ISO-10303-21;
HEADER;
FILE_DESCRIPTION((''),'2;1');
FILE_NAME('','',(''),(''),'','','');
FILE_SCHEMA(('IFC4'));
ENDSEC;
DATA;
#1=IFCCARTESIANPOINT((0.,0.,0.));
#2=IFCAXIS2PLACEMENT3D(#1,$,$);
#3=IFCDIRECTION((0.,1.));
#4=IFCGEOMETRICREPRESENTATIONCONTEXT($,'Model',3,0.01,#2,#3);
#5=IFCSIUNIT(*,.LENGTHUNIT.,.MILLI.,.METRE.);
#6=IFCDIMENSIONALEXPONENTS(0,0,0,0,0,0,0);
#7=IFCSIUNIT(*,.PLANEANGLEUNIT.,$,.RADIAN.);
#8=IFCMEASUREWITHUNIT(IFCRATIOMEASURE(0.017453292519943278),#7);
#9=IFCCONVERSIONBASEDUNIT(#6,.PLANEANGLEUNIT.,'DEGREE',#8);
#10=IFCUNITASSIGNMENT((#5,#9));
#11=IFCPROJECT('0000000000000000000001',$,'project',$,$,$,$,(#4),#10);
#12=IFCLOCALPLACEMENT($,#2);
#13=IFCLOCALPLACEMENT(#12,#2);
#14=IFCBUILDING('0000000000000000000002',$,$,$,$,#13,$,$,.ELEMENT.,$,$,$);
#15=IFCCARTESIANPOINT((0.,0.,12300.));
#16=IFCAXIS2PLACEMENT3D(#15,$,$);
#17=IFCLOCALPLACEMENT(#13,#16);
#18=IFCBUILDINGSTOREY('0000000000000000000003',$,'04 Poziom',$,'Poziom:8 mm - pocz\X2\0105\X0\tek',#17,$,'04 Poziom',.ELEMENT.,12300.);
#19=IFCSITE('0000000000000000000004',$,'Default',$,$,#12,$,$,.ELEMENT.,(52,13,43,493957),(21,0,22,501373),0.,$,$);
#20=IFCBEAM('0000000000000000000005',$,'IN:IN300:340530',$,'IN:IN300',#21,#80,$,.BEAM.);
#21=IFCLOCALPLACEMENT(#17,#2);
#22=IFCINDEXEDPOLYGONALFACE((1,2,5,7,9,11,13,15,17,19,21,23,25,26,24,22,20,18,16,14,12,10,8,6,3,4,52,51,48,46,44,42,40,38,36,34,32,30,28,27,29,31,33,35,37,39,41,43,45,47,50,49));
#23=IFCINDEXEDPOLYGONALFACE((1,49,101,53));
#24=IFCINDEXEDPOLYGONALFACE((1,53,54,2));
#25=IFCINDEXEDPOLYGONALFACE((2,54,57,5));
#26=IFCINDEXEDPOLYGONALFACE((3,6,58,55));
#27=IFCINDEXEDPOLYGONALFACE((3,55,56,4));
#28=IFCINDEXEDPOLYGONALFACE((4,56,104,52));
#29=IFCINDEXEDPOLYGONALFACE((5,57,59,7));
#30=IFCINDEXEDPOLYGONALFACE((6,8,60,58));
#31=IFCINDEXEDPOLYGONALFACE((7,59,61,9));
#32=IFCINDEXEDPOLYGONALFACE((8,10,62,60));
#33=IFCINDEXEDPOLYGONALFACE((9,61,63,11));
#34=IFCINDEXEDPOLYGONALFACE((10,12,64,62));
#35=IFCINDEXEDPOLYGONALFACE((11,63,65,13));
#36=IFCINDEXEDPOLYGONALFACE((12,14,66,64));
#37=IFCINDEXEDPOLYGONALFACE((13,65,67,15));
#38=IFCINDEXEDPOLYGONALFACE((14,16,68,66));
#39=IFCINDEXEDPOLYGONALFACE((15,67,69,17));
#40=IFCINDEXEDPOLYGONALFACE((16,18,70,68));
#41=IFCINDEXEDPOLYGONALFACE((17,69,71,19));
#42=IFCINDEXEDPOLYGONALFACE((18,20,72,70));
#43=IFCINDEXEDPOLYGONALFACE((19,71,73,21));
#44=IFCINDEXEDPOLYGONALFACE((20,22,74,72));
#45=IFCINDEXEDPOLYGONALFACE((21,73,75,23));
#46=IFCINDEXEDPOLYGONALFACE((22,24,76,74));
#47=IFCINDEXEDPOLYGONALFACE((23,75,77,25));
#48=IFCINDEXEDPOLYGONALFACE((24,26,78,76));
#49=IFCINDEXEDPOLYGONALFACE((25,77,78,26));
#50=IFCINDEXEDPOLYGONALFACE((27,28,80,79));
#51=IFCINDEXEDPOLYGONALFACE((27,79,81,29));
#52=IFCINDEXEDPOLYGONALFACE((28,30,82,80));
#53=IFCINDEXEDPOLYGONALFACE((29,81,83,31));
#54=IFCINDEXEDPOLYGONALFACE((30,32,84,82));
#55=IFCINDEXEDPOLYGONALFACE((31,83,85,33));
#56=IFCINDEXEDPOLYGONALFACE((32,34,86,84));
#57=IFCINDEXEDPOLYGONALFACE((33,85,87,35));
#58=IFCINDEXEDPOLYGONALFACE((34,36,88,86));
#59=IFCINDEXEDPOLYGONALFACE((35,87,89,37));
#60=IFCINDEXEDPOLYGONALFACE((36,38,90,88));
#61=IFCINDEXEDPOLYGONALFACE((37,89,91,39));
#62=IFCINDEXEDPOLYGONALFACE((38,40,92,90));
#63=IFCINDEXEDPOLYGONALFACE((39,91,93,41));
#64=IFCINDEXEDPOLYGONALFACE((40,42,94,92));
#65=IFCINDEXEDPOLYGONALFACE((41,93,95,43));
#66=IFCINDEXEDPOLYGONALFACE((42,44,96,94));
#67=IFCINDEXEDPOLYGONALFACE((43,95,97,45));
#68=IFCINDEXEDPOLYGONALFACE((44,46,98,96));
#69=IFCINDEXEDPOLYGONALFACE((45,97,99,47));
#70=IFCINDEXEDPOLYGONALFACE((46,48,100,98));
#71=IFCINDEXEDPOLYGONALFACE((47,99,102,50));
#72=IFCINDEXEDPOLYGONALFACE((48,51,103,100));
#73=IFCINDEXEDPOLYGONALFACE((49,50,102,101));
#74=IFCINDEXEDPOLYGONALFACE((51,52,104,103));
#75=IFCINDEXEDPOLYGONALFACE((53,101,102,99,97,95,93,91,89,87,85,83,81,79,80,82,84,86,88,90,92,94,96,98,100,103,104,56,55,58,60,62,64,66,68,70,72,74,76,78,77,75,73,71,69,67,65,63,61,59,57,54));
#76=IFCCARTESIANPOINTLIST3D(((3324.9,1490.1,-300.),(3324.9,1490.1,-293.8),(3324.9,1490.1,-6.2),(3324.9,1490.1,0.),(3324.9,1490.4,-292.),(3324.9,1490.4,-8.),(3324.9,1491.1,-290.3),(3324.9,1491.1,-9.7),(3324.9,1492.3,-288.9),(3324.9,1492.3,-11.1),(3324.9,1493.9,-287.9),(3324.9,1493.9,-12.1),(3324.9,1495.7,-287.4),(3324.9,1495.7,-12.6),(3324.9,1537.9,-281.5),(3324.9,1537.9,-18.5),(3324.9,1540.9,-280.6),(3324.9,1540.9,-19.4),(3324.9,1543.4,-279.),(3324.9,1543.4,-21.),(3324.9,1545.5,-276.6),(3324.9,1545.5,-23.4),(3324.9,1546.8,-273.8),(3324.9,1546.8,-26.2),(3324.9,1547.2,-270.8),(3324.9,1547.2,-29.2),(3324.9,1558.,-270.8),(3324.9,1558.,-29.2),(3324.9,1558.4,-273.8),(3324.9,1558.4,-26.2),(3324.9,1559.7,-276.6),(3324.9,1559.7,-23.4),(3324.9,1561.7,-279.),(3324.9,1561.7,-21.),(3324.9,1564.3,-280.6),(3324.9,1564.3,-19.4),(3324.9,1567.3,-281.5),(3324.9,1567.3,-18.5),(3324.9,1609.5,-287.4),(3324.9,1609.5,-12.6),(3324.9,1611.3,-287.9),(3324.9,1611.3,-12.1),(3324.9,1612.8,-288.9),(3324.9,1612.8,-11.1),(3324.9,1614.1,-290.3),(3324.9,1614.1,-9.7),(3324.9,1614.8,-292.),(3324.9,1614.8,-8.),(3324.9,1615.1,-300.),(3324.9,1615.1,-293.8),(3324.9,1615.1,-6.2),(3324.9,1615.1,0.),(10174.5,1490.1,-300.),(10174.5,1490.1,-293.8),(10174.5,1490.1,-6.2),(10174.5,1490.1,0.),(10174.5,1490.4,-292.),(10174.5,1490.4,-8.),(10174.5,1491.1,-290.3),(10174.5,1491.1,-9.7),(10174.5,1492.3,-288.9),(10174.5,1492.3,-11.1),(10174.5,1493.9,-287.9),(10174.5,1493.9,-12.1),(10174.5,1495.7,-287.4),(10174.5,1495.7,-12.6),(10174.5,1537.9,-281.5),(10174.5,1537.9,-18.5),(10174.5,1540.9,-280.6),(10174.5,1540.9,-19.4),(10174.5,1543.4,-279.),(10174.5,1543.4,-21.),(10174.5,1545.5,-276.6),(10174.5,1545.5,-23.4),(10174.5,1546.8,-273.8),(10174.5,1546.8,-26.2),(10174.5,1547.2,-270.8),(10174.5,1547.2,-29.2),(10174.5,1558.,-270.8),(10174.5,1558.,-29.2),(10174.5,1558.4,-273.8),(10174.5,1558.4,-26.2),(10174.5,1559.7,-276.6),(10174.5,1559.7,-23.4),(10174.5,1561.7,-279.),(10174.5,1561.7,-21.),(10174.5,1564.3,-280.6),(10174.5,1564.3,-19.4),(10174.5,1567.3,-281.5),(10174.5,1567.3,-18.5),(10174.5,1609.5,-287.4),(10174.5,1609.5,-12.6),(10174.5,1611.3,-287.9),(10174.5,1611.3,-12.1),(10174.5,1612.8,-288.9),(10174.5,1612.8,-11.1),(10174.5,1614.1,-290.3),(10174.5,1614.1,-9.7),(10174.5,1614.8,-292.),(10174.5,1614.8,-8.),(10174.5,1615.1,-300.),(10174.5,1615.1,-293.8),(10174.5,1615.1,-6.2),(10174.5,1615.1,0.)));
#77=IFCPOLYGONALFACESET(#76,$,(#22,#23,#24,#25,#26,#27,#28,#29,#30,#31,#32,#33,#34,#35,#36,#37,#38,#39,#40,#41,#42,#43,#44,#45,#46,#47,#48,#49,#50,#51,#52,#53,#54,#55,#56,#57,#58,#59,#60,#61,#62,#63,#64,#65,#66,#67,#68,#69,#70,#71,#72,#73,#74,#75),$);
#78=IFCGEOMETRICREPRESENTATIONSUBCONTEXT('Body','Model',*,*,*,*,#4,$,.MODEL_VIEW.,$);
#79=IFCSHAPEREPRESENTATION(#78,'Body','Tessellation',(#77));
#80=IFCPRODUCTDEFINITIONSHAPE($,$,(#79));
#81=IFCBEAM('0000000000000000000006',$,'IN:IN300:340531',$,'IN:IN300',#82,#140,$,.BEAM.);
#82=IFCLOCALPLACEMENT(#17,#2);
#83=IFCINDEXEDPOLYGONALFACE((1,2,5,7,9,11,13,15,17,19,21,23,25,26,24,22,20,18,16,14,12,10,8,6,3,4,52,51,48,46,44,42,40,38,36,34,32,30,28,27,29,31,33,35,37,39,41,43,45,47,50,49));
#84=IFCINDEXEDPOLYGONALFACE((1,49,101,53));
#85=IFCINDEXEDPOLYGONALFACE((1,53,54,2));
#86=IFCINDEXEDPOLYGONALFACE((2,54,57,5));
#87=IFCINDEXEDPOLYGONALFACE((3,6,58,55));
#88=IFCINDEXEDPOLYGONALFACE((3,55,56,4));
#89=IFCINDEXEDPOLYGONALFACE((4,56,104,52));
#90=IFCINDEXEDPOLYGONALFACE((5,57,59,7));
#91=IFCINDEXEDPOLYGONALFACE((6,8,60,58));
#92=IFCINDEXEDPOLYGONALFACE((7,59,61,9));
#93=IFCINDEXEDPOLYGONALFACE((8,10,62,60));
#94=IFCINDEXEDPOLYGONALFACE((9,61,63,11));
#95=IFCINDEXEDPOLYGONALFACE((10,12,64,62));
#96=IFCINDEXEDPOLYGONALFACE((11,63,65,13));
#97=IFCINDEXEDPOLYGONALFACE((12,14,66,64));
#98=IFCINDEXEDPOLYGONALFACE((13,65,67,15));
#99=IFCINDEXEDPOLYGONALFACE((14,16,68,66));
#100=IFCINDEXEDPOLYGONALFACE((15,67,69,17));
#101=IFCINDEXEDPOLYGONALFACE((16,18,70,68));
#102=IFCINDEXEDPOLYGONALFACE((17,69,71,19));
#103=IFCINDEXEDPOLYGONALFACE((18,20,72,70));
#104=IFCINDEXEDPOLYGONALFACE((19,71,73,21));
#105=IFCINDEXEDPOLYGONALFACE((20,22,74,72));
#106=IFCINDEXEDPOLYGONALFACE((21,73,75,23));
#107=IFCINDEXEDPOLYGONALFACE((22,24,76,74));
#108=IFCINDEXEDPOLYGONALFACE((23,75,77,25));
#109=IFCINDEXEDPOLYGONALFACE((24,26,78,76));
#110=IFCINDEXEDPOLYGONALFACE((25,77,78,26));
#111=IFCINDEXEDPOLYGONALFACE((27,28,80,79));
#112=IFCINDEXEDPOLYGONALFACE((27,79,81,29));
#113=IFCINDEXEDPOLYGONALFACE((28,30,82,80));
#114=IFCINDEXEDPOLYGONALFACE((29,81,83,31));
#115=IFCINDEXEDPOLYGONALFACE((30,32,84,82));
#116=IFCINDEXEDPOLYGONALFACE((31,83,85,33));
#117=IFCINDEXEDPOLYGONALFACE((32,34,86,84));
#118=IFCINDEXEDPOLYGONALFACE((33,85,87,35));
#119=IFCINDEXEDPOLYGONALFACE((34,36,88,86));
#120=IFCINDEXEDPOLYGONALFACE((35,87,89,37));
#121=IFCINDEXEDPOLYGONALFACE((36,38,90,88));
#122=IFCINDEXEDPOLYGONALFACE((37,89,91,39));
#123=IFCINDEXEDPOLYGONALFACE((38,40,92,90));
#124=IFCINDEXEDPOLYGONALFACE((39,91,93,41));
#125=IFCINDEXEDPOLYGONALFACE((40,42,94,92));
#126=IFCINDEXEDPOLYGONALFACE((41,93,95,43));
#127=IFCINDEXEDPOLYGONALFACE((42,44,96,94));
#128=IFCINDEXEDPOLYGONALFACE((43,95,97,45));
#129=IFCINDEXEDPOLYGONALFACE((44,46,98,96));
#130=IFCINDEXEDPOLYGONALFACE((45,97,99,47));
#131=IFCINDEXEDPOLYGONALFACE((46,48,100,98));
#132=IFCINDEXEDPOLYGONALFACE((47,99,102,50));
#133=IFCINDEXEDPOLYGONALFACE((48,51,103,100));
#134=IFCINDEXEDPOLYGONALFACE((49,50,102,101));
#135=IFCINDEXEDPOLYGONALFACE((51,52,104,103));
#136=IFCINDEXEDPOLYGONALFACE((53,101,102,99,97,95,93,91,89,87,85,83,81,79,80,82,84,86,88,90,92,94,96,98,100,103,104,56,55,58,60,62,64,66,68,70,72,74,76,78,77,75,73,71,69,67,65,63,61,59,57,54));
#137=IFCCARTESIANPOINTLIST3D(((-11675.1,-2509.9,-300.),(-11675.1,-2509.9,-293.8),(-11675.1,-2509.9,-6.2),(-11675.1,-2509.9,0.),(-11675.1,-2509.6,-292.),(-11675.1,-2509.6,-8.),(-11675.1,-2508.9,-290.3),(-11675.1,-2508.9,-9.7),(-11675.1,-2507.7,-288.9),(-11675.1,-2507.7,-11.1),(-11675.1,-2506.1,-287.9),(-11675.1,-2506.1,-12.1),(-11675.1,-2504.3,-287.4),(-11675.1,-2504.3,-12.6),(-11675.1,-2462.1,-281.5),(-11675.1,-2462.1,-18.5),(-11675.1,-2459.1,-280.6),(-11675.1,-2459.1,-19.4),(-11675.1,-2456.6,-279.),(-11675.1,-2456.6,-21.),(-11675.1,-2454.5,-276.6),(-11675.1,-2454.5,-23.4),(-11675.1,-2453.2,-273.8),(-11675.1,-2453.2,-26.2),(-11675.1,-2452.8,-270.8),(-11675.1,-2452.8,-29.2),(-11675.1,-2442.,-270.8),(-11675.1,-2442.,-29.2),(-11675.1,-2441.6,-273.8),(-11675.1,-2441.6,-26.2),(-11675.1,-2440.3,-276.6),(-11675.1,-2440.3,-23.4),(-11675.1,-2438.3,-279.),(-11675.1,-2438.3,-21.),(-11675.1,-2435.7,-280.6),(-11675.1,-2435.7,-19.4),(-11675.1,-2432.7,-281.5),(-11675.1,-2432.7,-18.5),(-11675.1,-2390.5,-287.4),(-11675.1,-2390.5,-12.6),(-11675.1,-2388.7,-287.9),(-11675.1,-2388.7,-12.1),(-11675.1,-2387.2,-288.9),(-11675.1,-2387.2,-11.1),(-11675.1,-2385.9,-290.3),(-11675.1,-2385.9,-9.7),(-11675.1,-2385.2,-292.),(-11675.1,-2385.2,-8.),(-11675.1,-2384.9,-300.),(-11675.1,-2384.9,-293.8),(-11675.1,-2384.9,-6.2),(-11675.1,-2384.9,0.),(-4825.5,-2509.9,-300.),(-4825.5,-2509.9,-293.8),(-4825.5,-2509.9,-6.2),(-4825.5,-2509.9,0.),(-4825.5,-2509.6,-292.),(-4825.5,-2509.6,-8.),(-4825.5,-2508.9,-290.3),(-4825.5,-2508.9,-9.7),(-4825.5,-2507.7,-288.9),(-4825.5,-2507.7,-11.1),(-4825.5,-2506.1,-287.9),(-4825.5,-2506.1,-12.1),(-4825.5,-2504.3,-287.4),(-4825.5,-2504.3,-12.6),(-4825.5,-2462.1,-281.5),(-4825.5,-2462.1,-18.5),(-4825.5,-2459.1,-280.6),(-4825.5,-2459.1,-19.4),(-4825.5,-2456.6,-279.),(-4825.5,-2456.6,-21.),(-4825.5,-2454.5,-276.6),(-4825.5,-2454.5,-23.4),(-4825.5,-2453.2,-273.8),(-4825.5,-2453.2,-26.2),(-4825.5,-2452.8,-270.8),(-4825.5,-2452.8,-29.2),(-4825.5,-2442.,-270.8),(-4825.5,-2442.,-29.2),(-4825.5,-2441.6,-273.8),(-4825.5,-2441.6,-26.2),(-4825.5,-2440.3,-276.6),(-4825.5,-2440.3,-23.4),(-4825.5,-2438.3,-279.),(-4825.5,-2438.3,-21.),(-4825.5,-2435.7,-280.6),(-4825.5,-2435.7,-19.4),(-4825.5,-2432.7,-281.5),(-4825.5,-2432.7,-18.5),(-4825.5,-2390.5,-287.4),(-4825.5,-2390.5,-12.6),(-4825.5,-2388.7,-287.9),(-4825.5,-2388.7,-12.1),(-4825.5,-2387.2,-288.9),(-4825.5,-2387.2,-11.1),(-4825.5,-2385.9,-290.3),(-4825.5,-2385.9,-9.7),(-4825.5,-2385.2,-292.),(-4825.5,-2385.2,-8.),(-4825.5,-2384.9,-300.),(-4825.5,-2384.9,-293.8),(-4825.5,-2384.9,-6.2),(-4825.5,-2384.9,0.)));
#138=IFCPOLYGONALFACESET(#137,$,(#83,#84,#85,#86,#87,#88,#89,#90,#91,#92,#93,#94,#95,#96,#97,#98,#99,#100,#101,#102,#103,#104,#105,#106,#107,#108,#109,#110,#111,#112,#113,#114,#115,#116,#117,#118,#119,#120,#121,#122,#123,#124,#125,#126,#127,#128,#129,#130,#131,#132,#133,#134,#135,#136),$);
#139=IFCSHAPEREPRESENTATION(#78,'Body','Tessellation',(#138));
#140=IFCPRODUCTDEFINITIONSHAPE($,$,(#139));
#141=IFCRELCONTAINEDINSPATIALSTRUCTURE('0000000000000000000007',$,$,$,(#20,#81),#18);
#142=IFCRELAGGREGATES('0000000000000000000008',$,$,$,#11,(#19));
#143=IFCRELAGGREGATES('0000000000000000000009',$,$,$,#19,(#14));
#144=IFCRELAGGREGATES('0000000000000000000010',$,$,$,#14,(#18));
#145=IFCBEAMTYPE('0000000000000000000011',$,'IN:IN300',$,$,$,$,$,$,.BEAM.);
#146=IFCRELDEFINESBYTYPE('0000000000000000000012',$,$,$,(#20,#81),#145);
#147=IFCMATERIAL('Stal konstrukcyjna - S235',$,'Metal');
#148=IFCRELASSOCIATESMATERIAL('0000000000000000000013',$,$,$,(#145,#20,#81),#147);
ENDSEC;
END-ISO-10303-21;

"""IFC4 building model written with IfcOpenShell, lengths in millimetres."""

from ifc_helpers import new_model, entity, si_unit, converted_unit, direction, frame, origin, place, context, subcontext, project, spatial, line, arc, indexed_curve, outline, extrude, source, transform, mapped, material, type_object, type_shapes, element, save


model = new_model("IFC4")

# Units and contexts
model_context = context("Model", 3, precision=0.01, world=origin(), true_north=direction((0.0, 1.0)))
body_context = subcontext(model_context, "Body", "Model", "MODEL_VIEW")
ifc_project = project(units=[si_unit("LENGTHUNIT", "METRE", prefix="MILLI"), converted_unit("PLANEANGLEUNIT", "DEGREE", entity("IfcRatioMeasure", 0.017453292519943278), si_unit("PLANEANGLEUNIT", "RADIAN"), dimensions=[0, 0, 0, 0, 0, 0, 0])], contexts=[model_context])

# Site, building, storey
site_placement = place(None, origin())
site = spatial("IfcSite", under=ifc_project, at=site_placement, Name="Default", CompositionType="ELEMENT", RefLatitude=(52, 13, 43, 493957), RefLongitude=(21, 0, 22, 501373), RefElevation=0.0)
building_placement = place(site_placement, origin())
building = spatial("IfcBuilding", under=site, at=building_placement, CompositionType="ELEMENT")
storey_placement = place(building_placement, frame((0.0, 0.0, 12300.0)))
storey = spatial("IfcBuildingStorey", under=building, at=storey_placement, Name="04 Poziom", ObjectType="Poziom:8 mm - początek", LongName="04 Poziom", CompositionType="ELEMENT", Elevation=12300.0)

# Shared definitions
ifc_material_1 = material(Name="Stal konstrukcyjna - S235", Category="Metal")

# Beams
beam_type_1 = type_object("IfcBeamType", Name="IN:IN300", PredefinedType="BEAM", material=ifc_material_1)
shared_shape_1 = source(origin(), body_context, "Body", "SweptSolid", [
    extrude(outline(indexed_curve([(143.8, -62.5), (150.0, -62.5), (150.0, 62.5), (143.8, 62.5), (139.6, 60.9), (137.4, 56.9), (131.5, 14.7), (127.9, 8.1), (120.8, 5.4), (-120.8, 5.4), (-127.9, 8.1), (-131.5, 14.7), (-137.4, 56.9), (-139.6, 60.9), (-143.8, 62.5), (-150.0, 62.5), (-150.0, -62.5), (-143.8, -62.5), (-139.6, -60.9), (-137.4, -56.9), (-131.5, -14.7), (-127.9, -8.1), (-120.8, -5.4), (120.8, -5.4), (127.9, -8.1), (131.5, -14.7), (137.4, -56.9), (139.6, -60.9)], segments=[line(1, 2, 3, 4), arc(4, 5, 6), line(6, 7), arc(7, 8, 9), line(9, 10), arc(10, 11, 12), line(12, 13), arc(13, 14, 15), line(15, 16, 17, 18), arc(18, 19, 20), line(20, 21), arc(21, 22, 23), line(23, 24), arc(24, 25, 26), line(26, 27), arc(27, 28, 1)], self_intersect=False)), frame((-3424.8, 0.0, 0.0), z_axis=(1.0, 0.0, 0.0), x_axis=(0.0, 0.0, -1.0)), (0.0, 0.0, 1.0), 6849.6),
])
type_shapes(beam_type_1, [shared_shape_1])
for number, where, name in (
    (1, (6749.7, 1552.6, -150.0), "IN:IN300:340530"),
    (2, (-8250.3, -2447.4, -150.0), "IN:IN300:340531"),
):
    element("IfcBeam", number, at=place(storey_placement, frame(where)), inside=storey, type_object=beam_type_1, material=ifc_material_1, Name=name, ObjectType="IN:IN300", PredefinedType="BEAM", context=body_context, shape_type="MappedRepresentation", body=[
        mapped(shared_shape_1, transform((0.0, 0.0, 0.0), scale=1.0)),
    ])

save(model, "model.ifc")
